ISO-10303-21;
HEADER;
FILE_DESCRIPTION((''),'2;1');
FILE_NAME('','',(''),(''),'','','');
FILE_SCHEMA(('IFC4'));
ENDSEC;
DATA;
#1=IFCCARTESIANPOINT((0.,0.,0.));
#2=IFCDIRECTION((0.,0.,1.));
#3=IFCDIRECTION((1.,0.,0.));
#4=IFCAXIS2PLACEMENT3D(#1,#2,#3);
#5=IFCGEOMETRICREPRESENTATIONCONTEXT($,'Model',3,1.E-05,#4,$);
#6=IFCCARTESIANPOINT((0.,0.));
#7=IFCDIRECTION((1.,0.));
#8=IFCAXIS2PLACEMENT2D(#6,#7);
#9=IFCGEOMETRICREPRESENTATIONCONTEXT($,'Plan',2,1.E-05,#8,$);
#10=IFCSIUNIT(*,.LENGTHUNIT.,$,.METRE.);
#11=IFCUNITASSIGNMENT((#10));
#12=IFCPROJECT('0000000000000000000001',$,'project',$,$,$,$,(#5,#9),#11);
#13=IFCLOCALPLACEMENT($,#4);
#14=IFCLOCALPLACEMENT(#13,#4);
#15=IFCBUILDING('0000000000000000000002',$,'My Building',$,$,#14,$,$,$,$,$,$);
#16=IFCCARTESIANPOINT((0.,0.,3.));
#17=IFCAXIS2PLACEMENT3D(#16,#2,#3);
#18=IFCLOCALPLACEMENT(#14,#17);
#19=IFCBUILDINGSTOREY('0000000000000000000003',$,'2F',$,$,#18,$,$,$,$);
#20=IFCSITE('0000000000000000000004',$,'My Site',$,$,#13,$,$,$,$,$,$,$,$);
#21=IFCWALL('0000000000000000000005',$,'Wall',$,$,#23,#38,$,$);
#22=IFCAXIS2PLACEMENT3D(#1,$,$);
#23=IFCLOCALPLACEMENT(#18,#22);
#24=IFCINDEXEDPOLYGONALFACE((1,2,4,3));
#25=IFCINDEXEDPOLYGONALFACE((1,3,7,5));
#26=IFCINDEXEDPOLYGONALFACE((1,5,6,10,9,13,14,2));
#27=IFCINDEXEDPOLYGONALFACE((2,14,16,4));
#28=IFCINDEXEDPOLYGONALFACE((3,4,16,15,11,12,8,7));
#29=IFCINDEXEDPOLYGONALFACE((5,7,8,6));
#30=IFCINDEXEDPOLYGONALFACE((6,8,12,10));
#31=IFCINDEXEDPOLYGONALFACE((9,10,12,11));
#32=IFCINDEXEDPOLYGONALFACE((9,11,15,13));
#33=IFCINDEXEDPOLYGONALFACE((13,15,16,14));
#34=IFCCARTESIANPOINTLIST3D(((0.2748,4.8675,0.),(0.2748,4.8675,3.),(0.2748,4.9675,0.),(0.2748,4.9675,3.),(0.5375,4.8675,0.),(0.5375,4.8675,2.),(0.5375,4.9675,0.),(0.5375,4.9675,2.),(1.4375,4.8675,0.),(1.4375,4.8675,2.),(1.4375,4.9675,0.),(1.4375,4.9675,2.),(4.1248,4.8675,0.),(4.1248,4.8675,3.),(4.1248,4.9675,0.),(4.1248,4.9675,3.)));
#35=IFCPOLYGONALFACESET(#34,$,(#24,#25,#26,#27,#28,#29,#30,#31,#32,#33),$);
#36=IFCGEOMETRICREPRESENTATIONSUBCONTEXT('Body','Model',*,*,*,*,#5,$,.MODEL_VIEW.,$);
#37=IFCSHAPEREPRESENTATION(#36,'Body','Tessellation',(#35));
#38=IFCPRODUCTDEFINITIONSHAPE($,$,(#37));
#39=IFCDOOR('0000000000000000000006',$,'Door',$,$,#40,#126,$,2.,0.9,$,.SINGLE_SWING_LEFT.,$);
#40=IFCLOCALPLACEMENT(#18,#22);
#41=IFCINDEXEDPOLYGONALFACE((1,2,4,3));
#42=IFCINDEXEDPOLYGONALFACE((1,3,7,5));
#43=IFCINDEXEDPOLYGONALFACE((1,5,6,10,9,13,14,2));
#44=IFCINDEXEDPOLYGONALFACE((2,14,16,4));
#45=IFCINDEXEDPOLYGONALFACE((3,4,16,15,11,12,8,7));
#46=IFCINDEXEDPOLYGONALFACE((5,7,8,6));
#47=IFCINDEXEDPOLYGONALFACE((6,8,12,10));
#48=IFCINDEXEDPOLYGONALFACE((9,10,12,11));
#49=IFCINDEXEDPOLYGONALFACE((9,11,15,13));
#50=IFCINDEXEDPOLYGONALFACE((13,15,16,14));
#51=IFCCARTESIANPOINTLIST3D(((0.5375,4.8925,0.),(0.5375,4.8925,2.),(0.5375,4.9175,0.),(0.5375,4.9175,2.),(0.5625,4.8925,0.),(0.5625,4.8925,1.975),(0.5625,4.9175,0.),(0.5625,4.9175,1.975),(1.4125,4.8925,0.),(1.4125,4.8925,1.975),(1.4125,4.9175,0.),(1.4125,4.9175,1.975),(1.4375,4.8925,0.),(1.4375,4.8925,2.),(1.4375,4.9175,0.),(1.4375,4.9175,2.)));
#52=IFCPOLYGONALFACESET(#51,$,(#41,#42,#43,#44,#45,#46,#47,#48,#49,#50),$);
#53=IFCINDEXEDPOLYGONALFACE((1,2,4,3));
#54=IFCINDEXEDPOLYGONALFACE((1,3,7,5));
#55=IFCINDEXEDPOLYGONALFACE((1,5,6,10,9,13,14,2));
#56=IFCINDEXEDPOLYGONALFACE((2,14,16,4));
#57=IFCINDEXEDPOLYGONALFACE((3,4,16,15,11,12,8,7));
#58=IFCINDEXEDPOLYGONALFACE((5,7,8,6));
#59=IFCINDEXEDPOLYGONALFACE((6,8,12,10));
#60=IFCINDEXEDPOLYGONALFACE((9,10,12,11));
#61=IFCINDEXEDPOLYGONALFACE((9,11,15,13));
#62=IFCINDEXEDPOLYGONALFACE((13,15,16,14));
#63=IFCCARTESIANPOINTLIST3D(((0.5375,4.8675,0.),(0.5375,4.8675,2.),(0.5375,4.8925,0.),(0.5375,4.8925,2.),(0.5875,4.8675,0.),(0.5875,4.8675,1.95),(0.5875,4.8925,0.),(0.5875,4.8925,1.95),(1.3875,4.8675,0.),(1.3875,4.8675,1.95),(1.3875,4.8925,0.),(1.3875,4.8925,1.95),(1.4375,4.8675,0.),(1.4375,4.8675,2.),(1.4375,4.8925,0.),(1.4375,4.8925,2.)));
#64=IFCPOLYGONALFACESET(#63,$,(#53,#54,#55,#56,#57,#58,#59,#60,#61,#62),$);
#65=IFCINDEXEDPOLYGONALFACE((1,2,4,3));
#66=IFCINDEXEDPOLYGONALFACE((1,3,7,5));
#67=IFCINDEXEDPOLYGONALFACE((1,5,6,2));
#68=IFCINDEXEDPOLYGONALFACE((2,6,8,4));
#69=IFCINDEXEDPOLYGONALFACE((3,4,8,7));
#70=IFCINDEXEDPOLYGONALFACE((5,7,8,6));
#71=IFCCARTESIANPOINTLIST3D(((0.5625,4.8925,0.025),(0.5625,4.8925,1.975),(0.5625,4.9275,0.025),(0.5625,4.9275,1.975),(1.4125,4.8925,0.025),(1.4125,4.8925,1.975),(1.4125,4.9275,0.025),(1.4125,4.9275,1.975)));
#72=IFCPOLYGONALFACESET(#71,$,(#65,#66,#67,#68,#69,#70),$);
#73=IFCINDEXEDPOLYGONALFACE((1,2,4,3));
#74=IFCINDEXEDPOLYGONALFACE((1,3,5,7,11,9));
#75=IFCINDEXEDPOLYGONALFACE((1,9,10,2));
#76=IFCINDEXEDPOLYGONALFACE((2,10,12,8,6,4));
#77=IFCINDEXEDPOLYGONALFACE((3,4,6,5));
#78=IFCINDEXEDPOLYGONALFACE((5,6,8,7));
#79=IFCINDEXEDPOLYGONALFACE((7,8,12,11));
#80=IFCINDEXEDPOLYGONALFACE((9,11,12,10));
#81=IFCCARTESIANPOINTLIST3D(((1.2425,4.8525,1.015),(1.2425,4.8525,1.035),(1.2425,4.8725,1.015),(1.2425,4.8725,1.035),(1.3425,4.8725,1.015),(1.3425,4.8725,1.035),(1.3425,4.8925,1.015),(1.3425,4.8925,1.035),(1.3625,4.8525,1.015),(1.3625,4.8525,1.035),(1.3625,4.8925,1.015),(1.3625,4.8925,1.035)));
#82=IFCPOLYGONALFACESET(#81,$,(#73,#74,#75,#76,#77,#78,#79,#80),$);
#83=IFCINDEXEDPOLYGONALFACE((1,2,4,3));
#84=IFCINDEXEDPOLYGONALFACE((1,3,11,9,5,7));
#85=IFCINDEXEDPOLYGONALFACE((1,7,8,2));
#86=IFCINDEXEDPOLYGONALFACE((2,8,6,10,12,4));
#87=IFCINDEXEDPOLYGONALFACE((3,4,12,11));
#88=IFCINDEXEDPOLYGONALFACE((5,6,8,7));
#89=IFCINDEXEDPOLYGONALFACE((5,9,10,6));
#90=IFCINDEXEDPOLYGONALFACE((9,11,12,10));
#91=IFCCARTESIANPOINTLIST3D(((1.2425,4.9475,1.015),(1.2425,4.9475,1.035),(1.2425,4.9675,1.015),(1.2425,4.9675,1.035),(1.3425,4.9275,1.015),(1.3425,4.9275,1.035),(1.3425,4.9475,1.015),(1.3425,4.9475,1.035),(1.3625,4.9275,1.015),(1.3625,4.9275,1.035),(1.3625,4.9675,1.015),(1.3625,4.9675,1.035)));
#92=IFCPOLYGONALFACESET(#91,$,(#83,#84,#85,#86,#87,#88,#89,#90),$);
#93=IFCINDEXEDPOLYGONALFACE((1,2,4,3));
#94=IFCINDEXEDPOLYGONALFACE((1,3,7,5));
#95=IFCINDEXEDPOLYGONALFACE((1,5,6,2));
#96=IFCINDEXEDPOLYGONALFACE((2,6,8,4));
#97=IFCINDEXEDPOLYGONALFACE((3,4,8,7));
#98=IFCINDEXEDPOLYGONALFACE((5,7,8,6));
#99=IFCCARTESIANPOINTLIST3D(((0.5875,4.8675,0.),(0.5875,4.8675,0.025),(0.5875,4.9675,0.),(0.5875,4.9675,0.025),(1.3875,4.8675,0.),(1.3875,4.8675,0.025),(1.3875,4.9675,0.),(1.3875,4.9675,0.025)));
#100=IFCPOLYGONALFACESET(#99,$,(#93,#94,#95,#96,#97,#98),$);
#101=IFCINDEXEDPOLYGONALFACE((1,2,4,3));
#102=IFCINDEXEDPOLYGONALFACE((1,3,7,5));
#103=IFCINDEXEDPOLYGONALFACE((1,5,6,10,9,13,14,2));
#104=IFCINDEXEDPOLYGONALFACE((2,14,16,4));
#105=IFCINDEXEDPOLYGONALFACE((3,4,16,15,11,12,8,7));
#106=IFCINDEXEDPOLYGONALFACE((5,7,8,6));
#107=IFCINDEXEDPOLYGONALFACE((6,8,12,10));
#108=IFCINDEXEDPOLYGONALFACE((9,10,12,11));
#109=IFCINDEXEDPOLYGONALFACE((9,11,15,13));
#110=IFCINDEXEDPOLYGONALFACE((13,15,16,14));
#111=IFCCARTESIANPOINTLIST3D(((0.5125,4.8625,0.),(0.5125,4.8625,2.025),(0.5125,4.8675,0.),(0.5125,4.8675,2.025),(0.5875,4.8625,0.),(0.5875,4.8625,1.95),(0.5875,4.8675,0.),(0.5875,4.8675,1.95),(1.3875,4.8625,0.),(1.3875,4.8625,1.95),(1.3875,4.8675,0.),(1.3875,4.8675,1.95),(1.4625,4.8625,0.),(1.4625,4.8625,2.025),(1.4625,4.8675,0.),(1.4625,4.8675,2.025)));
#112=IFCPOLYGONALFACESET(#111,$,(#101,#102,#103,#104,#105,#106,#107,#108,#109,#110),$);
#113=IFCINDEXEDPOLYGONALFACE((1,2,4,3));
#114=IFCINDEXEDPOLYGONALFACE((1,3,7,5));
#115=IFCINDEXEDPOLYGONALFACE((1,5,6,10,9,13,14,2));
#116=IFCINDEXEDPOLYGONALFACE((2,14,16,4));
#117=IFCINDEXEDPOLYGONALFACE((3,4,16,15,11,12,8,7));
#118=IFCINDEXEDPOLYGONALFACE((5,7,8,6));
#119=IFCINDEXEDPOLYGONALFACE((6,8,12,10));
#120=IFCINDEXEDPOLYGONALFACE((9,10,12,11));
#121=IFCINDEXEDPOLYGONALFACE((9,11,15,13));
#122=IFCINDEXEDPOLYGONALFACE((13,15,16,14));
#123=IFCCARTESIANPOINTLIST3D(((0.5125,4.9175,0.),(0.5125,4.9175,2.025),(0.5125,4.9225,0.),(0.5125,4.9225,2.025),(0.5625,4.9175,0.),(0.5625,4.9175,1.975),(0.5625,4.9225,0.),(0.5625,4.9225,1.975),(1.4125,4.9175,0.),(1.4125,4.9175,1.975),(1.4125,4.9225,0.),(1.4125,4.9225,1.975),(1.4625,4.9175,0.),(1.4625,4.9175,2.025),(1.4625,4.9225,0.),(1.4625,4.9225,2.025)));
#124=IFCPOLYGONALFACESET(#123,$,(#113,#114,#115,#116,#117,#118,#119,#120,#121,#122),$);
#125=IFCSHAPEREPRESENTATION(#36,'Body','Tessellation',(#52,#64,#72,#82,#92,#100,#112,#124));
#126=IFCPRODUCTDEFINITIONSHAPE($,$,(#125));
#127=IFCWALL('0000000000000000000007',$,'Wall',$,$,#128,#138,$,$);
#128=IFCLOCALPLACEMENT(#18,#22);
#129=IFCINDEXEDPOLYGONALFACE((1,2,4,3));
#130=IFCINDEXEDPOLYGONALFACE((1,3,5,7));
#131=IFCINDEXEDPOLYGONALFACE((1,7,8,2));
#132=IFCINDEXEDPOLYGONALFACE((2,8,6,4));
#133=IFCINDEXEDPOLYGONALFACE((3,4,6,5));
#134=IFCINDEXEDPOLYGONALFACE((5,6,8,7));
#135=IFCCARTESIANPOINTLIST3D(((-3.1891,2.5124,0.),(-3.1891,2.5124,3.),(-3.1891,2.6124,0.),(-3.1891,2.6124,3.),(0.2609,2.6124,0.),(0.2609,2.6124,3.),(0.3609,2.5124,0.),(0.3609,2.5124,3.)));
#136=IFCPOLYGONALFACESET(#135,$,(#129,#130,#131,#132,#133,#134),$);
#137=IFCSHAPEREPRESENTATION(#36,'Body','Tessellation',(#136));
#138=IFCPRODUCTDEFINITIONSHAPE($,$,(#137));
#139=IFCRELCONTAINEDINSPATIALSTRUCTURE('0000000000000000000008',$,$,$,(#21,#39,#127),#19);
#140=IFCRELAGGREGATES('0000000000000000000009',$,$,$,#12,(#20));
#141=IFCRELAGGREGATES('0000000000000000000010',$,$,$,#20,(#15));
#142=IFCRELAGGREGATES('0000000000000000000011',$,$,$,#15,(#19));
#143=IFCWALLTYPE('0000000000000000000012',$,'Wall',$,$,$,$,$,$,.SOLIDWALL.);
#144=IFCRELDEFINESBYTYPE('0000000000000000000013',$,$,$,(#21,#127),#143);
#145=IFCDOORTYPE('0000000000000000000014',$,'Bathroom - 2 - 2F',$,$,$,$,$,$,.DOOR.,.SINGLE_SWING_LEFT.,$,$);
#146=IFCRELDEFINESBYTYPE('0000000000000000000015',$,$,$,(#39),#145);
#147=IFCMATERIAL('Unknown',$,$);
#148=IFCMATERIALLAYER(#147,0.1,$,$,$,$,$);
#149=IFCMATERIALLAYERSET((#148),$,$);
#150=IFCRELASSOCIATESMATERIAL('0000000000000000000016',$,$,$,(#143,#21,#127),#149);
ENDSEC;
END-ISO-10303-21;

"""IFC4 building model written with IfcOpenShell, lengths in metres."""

from ifc_helpers import new_model, entity, si_unit, frame, origin_with_axes, origin_2d_with_axis, place, context, subcontext, project, spatial, line, indexed_curve, outline, extrude, shape, source, transform, mapped, material, layer, layer_set, layer_usage, type_object, type_shapes, element, fill, save


model = new_model("IFC4")

# Units and contexts
model_context = context("Model", 3, precision=1e-05, world=origin_with_axes())
plan_context = context("Plan", 2, precision=1e-05, world=origin_2d_with_axis())
body_context_1 = subcontext(model_context, "Body", "Model", "MODEL_VIEW")
body_context_2 = subcontext(plan_context, "Body", "Plan", "PLAN_VIEW")
ifc_project = project(units=[si_unit("LENGTHUNIT", "METRE")], contexts=[model_context, plan_context])

# Site, building, storey
site_placement = place(None, origin_with_axes())
site = spatial("IfcSite", under=ifc_project, at=site_placement, Name="My Site")
building_placement = place(site_placement, origin_with_axes())
building = spatial("IfcBuilding", under=site, at=building_placement, Name="My Building")
storey_placement = place(building_placement, frame((0.0, 0.0, 3.0), z_axis=(0.0, 0.0, 1.0), x_axis=(1.0, 0.0, 0.0)))
storey = spatial("IfcBuildingStorey", under=building, at=storey_placement, Name="2F")

# Shared definitions
ifc_material = material(Name="Unknown")

# Shared definitions
ifc_layer_1 = layer(ifc_material, 0.1)
ifc_layer_set_1 = layer_set([ifc_layer_1])
wall_type = type_object("IfcWallType", Name="Wall", PredefinedType="SOLIDWALL", material=ifc_layer_set_1)

# Wall, opening, door
ifc_layer_usage_1 = layer_usage(ifc_layer_set_1, "AXIS2", "POSITIVE", 0.0)
wall_1_placement = place(storey_placement, frame((4.1248, 4.9675, 0.0), z_axis=(0.0, 0.0, 1.0), x_axis=(-1.0, 0.0, 0.0)))
wall_1 = element("IfcWall", 1, at=wall_1_placement, inside=storey, type_object=wall_type, material=ifc_layer_usage_1, Name="Wall", context=body_context_1, shape_type="SweptSolid", body=[
    extrude(outline(indexed_curve([(0.0, 0.0), (0.0, 0.1), (3.85, 0.1), (3.85, 0.0)], segments=[line(1, 2, 3, 4, 1)])), origin_with_axes(), (0.0, 0.0, 1.0), 3.0),
])
shared_shape_1 = source(origin_with_axes(), body_context_1, "Body", "SweptSolid", [
    extrude(outline(indexed_curve([(0.0, 0.0), (0.9, 0.0), (0.9, 2.0), (0.0, 2.0)], segments=[line(1, 2, 3, 4, 1)])), frame((0.0, -0.6, 0.0), z_axis=(0.0, -1.0, 0.0), x_axis=(1.0, 0.0, 0.0)), (0.0, 0.0, -1.0), 1.2),
])
opening_1_placement = place(wall_1_placement, frame((3.5873, 0.1, 0.0), z_axis=(0.0, 0.0, 1.0), x_axis=(-1.0, 0.0, 0.0)))
opening_1 = element("IfcOpeningElement", 2, at=opening_1_placement, cuts=wall_1, PredefinedType="OPENING", context=body_context_1, shape_type="MappedRepresentation", body=[
    mapped(shared_shape_1, transform((0.0, 0.0, 0.0), x_axis=(1.0, 0.0, 0.0), y_axis=(0.0, 1.0, 0.0), z_axis=(0.0, 0.0, 1.0), scale=1.0)),
])
door_type_1 = type_object("IfcDoorType", Name="Bathroom - 2 - 2F", OperationType="SINGLE_SWING_LEFT", PredefinedType="DOOR")
shared_shape_2 = source(origin_with_axes(), body_context_1, "Body", "SweptSolid", [
    extrude(outline(indexed_curve([(0.0, 0.0), (0.0, 2.0), (0.9, 2.0), (0.9, 0.0), (0.875, 0.0), (0.875, 1.975), (0.025, 1.975), (0.025, 0.0)], segments=[line(1, 2, 3, 4, 5, 6, 7, 8, 1)])), frame((0.0, 0.025, 0.0), z_axis=(0.0, -1.0, 0.0), x_axis=(1.0, 0.0, 0.0)), (0.0, 0.0, -1.0), 0.025),
    extrude(outline(indexed_curve([(0.0, 0.0), (0.0, 2.0), (0.9, 2.0), (0.9, 0.0), (0.85, 0.0), (0.85, 1.95), (0.05, 1.95), (0.05, 0.0)], segments=[line(1, 2, 3, 4, 5, 6, 7, 8, 1)])), frame((0.0, 0.0, 0.0), z_axis=(0.0, -1.0, 0.0), x_axis=(1.0, 0.0, 0.0)), (0.0, 0.0, -1.0), 0.025),
    extrude(outline(indexed_curve([(0.0, 0.0), (0.85, 0.0), (0.85, 0.035), (0.0, 0.035)], segments=[line(1, 2, 3, 4, 1)])), frame((0.025, 0.025, 0.025), z_axis=(0.0, 0.0, 1.0), x_axis=(1.0, 0.0, 0.0)), (0.0, 0.0, 1.0), 1.95),
    extrude(outline(indexed_curve([(0.0, 0.0), (0.0, -0.04), (-0.12, -0.04), (-0.12, -0.02), (-0.02, -0.02), (-0.02, 0.0)], segments=[line(1, 2, 3, 4, 5, 6, 1)])), frame((0.825, 0.025, 1.015), z_axis=(0.0, 0.0, 1.0), x_axis=(1.0, 0.0, 0.0)), (0.0, 0.0, 1.0), 0.02),
    extrude(outline(indexed_curve([(0.0, 0.0), (0.0, 0.04), (-0.12, 0.04), (-0.12, 0.02), (-0.02, 0.02), (-0.02, 0.0)], segments=[line(1, 2, 3, 4, 5, 6, 1)])), frame((0.825, 0.06, 1.015), z_axis=(0.0, 0.0, 1.0), x_axis=(1.0, 0.0, 0.0)), (0.0, 0.0, 1.0), 0.02),
    extrude(outline(indexed_curve([(0.0, 0.0), (0.8, 0.0), (0.8, 0.1), (0.0, 0.1)], segments=[line(1, 2, 3, 4, 1)])), frame((0.05, 0.0, 0.0), z_axis=(0.0, 0.0, 1.0), x_axis=(1.0, 0.0, 0.0)), (0.0, 0.0, 1.0), 0.025),
    extrude(outline(indexed_curve([(0.0, 0.0), (0.0, 2.025), (0.95, 2.025), (0.95, 0.0), (0.875, 0.0), (0.875, 1.95), (0.075, 1.95), (0.075, 0.0)], segments=[line(1, 2, 3, 4, 5, 6, 7, 8, 1)])), frame((-0.025, -0.005, 0.0), z_axis=(0.0, -1.0, 0.0), x_axis=(1.0, 0.0, 0.0)), (0.0, 0.0, -1.0), 0.005),
    extrude(outline(indexed_curve([(0.0, 0.0), (0.0, 2.025), (0.95, 2.025), (0.95, 0.0), (0.9, 0.0), (0.9, 1.975), (0.05, 1.975), (0.05, 0.0)], segments=[line(1, 2, 3, 4, 5, 6, 7, 8, 1)])), frame((-0.025, 0.05, 0.0), z_axis=(0.0, -1.0, 0.0), x_axis=(1.0, 0.0, 0.0)), (0.0, 0.0, -1.0), 0.005),
])
shared_shape_3 = source(origin_with_axes(), body_context_2, "Body", "Curve2D", [
    entity("IfcIndexedPolyCurve", entity("IfcCartesianPointList2D", [[0.0, 0.0], [0.0, 0.05], [0.025, 0.05], [0.025, 0.025], [0.05, 0.025], [0.05, 0.0]]), [entity("IfcLineIndex", [1, 2, 3, 4, 5, 6, 1])]),
    entity("IfcIndexedPolyCurve", entity("IfcCartesianPointList2D", [[0.9, 0.0], [0.9, 0.05], [0.875, 0.05], [0.875, 0.025], [0.85, 0.025], [0.85, 0.0]]), [entity("IfcLineIndex", [1, 2, 3, 4, 5, 6, 1])]),
    entity("IfcTrimmedCurve", entity("IfcEllipse", entity("IfcAxis2Placement2D", entity("IfcCartesianPoint", [0.06, 0.05]), entity("IfcDirection", [1.0, 0.0])), 0.815, 0.85), [entity("IfcCartesianPoint", [0.875, 0.05])], [entity("IfcCartesianPoint", [0.06, 0.9])], True, "CARTESIAN"),
    entity("IfcIndexedPolyCurve", entity("IfcCartesianPointList2D", [[0.025, 0.05], [0.06, 0.05], [0.06, 0.9], [0.025, 0.9]]), [entity("IfcLineIndex", [1, 2, 3, 4, 1])]),
])
type_shapes(door_type_1, [shared_shape_2, shared_shape_3])
door_1_placement = place(opening_1_placement, frame((0.0, 0.0, 0.0), z_axis=(0.0, 0.0, 1.0), x_axis=(1.0, 0.0, 0.0)))
door_1 = element("IfcDoor", 3, at=door_1_placement, inside=storey, type_object=door_type_1, Name="Door", OperationType="SINGLE_SWING_LEFT", OverallHeight=2.0, OverallWidth=0.9, shapes=[
    shape(body_context_1, "Body", "MappedRepresentation", [mapped(shared_shape_2, transform((0.0, 0.0, 0.0), x_axis=(1.0, 0.0, 0.0), y_axis=(0.0, 1.0, 0.0), z_axis=(0.0, 0.0, 1.0), scale=1.0))]),
    shape(body_context_2, "Body", "MappedRepresentation", [mapped(shared_shape_3, transform((0.0, 0.0, 0.0), x_axis=(1.0, 0.0, 0.0), y_axis=(0.0, 1.0, 0.0), z_axis=(0.0, 0.0, 1.0), scale=1.0))]),
])
fill(opening_1, door_1)

# Wall
ifc_layer_usage_2 = layer_usage(ifc_layer_set_1, "AXIS2", "POSITIVE", 0.0)
wall_2_placement = place(storey_placement, frame((-3.1891, 2.5124, 0.0), z_axis=(0.0, 0.0, 1.0), x_axis=(1.0, 0.0, 0.0)))
element("IfcWall", 4, at=wall_2_placement, inside=storey, type_object=wall_type, material=ifc_layer_usage_2, Name="Wall", context=body_context_1, shape_type="SweptSolid", body=[
    extrude(outline(indexed_curve([(0.0, 0.0), (0.0, 0.1), (3.45, 0.1), (3.55, 0.0)], segments=[line(1, 2, 3, 4, 1)])), origin_with_axes(), (0.0, 0.0, 1.0), 3.0),
])

save(model, "model.ifc")
